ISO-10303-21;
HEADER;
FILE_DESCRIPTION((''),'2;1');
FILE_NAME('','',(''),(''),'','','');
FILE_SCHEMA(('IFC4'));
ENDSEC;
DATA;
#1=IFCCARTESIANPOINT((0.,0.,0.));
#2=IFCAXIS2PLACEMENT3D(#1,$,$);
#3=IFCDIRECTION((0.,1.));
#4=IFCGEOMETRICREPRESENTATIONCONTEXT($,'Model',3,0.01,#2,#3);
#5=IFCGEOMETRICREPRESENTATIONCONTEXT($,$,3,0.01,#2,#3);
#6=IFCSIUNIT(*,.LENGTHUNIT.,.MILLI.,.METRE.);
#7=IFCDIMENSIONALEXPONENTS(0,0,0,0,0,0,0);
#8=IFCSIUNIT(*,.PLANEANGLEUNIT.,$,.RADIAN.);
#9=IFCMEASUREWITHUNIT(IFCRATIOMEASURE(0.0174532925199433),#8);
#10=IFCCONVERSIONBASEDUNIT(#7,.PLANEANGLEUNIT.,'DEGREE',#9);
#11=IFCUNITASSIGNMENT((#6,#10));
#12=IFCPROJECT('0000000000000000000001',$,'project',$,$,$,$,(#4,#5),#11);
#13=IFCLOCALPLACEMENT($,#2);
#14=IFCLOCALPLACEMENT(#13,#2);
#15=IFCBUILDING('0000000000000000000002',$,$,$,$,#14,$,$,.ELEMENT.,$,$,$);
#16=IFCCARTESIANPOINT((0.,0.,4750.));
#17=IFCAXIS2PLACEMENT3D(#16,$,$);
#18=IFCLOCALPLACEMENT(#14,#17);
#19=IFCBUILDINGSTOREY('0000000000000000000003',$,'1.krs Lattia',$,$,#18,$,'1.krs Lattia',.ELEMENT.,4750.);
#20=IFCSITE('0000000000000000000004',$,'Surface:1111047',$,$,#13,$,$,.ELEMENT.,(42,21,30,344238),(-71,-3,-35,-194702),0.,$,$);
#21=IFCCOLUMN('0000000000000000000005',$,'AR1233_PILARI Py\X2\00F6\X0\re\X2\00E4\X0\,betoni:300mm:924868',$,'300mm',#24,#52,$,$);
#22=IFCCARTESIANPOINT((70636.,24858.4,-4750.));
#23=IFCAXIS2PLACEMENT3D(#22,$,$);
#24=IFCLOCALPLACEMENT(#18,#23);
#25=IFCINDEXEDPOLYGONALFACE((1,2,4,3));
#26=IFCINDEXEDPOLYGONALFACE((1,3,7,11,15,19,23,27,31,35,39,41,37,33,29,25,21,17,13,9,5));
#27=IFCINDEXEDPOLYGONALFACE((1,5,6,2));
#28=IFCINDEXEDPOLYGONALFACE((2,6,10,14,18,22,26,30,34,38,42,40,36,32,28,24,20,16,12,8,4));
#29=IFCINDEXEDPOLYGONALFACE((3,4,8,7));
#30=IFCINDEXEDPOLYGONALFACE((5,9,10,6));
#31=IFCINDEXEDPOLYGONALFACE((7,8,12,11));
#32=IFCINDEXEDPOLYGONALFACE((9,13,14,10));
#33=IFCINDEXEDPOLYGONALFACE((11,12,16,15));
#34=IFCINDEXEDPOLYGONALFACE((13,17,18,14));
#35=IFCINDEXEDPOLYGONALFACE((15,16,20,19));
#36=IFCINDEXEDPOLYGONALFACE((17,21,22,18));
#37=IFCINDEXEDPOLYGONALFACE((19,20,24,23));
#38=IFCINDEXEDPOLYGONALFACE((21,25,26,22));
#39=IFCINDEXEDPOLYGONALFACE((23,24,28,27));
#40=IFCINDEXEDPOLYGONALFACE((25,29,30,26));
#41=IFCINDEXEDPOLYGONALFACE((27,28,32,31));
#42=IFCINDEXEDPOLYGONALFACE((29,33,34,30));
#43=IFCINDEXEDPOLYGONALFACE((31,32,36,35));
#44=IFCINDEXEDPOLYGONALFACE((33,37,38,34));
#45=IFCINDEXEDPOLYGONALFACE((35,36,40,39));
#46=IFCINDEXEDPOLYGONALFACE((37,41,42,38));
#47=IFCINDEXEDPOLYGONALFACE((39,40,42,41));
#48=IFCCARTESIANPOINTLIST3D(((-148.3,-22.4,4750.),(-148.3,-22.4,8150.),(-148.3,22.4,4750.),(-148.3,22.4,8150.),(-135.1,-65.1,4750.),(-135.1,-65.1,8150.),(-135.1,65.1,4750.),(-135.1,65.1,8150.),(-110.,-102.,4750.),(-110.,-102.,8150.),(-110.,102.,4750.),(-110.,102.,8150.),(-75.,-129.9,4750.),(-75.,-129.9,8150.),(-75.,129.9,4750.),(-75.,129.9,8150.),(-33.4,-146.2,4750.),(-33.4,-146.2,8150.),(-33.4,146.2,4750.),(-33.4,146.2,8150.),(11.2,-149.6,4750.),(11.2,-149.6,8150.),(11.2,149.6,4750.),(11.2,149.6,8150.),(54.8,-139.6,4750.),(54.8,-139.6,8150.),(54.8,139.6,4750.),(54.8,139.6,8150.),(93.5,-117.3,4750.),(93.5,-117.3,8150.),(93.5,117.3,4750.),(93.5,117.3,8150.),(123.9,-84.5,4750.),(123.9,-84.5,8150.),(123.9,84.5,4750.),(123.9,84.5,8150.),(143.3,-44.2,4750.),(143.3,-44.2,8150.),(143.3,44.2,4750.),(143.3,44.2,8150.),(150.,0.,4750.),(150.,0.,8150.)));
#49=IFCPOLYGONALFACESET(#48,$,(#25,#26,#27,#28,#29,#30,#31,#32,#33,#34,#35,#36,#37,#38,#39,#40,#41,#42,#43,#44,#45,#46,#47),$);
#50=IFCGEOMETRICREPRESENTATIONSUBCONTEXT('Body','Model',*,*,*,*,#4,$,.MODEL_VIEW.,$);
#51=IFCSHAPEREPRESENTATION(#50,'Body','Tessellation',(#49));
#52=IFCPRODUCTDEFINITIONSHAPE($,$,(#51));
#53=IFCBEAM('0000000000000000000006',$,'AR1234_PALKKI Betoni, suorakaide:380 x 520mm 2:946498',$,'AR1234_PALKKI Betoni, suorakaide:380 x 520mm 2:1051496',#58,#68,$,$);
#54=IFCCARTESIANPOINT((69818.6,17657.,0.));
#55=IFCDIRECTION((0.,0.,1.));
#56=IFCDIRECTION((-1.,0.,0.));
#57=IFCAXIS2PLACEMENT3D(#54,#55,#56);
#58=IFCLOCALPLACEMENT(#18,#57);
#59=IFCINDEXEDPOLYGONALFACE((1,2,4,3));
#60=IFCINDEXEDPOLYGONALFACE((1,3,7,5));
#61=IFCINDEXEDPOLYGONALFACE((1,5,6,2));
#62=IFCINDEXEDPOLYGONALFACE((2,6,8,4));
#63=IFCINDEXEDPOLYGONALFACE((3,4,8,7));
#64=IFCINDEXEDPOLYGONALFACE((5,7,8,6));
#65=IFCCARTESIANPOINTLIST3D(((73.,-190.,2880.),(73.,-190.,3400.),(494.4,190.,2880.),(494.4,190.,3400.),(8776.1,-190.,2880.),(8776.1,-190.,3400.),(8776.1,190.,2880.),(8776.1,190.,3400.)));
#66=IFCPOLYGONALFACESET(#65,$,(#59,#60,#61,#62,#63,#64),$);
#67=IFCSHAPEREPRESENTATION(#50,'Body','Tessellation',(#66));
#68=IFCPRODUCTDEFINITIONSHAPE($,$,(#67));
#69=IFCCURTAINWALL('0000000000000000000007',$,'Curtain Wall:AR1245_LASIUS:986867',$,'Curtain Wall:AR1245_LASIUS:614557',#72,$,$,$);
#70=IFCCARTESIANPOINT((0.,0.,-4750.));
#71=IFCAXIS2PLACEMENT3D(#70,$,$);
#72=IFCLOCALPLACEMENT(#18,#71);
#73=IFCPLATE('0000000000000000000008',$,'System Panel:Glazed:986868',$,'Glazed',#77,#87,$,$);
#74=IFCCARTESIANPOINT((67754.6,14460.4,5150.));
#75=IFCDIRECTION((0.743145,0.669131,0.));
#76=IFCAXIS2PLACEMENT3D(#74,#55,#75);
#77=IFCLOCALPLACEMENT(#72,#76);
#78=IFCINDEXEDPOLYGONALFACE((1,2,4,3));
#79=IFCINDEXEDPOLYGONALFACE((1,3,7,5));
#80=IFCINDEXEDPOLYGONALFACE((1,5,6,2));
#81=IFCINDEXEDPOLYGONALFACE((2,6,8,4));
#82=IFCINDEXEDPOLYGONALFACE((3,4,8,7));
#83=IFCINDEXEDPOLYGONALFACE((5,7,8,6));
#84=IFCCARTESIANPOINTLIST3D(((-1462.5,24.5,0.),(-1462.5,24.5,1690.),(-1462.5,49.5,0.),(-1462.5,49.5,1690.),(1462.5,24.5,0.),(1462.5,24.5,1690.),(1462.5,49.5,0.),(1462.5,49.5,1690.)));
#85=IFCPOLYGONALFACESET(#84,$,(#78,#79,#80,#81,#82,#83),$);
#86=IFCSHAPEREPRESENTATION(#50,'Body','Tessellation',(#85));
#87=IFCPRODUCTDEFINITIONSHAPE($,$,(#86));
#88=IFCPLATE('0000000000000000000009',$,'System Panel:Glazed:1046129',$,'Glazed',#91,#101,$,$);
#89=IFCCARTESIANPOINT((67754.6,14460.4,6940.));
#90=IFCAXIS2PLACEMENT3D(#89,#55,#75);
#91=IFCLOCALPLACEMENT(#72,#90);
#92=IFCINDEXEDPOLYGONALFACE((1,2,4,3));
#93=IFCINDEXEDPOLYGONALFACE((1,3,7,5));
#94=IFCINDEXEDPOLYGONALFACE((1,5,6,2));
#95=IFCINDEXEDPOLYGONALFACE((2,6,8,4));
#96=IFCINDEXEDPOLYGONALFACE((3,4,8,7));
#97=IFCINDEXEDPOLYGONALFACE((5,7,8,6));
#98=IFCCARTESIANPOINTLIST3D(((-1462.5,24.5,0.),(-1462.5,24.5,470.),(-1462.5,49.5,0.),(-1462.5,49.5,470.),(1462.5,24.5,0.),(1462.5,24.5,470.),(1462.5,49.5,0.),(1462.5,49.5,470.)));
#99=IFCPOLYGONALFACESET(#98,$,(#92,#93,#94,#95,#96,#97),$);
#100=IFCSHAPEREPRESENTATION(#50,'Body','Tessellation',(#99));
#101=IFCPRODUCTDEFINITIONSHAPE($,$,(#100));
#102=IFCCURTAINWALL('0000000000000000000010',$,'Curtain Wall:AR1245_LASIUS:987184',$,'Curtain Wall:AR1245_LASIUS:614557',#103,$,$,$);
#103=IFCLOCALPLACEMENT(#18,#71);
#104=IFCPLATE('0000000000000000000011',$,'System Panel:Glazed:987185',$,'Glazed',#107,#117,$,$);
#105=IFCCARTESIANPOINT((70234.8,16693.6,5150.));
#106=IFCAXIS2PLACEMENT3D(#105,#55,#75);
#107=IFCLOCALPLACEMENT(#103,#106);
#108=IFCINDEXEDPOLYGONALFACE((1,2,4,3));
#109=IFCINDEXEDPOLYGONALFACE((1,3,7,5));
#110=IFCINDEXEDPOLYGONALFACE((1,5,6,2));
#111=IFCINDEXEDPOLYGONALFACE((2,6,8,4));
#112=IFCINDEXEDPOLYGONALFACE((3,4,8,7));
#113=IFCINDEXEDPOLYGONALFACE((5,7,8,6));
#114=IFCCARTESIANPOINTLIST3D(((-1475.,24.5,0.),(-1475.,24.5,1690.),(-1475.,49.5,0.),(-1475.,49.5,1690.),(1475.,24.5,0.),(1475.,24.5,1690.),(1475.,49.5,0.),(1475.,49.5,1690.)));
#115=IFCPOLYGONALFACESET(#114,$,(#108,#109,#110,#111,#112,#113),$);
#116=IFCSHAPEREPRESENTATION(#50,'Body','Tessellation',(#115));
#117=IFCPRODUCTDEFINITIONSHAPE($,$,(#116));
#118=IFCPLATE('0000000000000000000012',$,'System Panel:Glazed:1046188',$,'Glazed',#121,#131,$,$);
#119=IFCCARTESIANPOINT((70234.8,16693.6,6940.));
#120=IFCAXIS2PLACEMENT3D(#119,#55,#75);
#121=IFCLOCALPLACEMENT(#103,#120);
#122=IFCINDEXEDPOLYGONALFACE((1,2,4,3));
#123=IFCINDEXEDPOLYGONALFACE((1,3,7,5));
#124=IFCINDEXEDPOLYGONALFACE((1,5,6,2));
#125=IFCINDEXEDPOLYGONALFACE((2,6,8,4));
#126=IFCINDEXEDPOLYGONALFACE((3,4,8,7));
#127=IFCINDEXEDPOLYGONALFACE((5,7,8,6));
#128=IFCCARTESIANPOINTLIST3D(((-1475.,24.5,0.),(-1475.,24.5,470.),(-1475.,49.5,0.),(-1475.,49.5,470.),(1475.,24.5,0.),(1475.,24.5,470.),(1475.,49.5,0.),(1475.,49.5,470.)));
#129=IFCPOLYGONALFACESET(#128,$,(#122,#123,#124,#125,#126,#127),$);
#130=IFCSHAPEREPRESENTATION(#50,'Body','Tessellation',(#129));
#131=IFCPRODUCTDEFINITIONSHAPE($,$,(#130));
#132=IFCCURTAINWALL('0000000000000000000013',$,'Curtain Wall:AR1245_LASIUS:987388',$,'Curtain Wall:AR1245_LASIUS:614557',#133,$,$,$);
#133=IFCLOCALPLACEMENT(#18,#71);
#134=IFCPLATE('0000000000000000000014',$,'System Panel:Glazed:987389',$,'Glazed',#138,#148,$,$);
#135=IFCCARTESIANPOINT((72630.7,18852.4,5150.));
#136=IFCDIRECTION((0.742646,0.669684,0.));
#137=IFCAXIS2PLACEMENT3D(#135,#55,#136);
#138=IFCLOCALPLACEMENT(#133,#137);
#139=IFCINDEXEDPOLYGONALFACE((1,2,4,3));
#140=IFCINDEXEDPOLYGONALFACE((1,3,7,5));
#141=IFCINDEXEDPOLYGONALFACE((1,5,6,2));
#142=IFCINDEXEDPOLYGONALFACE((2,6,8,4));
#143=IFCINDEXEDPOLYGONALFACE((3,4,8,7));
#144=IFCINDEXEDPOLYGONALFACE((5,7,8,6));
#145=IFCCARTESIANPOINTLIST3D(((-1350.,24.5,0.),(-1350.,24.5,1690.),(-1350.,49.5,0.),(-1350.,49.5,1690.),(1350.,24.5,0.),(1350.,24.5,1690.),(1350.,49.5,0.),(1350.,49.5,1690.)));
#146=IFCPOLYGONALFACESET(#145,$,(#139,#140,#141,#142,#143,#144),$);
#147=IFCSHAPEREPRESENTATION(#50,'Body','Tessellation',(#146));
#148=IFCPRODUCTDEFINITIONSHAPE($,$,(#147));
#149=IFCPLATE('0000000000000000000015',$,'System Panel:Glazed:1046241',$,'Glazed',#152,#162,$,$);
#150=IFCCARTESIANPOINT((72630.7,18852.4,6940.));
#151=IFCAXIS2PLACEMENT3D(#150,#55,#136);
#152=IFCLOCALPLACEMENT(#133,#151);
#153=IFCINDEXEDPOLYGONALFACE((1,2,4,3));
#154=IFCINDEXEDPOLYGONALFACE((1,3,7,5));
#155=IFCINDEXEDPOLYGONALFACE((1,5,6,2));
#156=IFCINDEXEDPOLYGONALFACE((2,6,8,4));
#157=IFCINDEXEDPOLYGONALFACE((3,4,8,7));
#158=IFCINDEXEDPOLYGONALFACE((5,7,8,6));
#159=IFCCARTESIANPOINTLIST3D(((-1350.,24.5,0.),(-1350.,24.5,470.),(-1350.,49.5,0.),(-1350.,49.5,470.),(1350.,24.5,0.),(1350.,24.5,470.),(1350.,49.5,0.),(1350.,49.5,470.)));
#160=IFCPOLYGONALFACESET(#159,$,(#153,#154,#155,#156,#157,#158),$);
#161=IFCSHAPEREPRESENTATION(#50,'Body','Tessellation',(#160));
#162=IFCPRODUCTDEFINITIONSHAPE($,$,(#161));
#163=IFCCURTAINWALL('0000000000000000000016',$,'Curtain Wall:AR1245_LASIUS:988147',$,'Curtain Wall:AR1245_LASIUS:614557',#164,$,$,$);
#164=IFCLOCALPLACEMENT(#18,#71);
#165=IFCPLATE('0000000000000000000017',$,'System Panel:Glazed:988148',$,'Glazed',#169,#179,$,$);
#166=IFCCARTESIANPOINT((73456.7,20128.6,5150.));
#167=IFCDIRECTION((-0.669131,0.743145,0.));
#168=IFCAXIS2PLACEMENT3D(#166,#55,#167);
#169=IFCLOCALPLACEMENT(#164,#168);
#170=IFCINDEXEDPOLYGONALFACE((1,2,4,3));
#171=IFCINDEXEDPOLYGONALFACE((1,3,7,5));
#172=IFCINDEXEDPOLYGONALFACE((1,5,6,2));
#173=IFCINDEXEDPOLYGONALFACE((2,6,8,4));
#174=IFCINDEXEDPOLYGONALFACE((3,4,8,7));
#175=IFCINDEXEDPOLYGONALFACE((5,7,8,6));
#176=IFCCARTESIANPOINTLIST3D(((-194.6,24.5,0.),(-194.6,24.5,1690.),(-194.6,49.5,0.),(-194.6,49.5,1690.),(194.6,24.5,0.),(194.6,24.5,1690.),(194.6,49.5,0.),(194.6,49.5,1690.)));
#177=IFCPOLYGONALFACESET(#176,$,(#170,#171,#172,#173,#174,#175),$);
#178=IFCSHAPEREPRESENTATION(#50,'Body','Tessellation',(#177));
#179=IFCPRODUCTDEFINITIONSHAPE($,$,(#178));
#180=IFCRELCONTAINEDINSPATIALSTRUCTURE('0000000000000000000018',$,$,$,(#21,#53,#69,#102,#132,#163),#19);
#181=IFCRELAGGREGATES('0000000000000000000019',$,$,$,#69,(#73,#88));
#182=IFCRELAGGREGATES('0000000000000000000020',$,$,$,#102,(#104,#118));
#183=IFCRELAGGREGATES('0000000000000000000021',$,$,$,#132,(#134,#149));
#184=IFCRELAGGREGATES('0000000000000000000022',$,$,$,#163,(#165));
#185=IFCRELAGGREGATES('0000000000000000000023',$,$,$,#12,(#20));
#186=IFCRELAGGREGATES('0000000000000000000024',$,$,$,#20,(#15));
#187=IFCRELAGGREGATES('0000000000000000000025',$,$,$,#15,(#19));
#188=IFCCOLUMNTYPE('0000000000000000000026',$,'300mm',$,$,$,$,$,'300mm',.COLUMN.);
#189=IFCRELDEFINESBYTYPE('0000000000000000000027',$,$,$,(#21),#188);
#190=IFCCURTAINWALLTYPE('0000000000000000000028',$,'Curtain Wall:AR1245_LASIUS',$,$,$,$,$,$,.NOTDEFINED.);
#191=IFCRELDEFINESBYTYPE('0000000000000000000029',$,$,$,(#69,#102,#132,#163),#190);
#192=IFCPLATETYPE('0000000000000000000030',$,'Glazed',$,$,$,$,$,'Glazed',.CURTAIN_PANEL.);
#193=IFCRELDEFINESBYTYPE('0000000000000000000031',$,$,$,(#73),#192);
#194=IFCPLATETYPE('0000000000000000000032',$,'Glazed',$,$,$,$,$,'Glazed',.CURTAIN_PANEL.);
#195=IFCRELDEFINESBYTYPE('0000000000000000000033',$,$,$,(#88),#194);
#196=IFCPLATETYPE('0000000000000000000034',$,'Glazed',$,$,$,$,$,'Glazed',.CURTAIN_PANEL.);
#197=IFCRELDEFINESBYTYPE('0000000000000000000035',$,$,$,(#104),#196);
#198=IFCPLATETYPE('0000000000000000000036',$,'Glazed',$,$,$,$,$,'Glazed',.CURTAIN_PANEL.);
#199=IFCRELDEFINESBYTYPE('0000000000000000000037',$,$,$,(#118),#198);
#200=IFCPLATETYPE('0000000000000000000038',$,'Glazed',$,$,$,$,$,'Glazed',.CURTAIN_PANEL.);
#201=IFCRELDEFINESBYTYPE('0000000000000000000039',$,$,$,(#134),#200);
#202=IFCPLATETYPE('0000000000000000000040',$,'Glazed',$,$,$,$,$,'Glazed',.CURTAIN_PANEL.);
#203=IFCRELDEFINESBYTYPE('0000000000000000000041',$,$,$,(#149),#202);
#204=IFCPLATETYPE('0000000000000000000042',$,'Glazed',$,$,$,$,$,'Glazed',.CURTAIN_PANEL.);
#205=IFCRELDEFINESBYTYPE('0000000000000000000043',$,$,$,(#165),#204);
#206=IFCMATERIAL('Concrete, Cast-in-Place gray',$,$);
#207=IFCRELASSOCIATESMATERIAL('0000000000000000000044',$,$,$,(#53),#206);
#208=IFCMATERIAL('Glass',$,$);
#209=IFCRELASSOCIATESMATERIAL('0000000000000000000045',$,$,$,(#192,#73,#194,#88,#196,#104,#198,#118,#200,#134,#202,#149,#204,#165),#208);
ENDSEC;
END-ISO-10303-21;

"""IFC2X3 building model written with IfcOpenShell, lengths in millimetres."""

from ifc_helpers import new_model, entity, si_unit, converted_unit, direction, frame, frame_2d, origin, origin_2d_with_axis, place, context, subcontext, project, spatial, rectangle, circle, extrude, clip, halfspace, source, transform, mapped, material, type_object, type_shapes, element, aggregate, save


model = new_model("IFC2X3")

# Units and contexts
model_context = context("Model", 3, precision=0.01, world=origin(), true_north=direction((0.0, 1.0)))
context_of_model = context(None, 3, precision=0.01, world=origin(), true_north=direction((0.0, 1.0)))
body_context = subcontext(model_context, "Body", "Model", "MODEL_VIEW")
ifc_project = project(units=[si_unit("LENGTHUNIT", "METRE", prefix="MILLI"), converted_unit("PLANEANGLEUNIT", "DEGREE", entity("IfcRatioMeasure", 0.0174532925199433), si_unit("PLANEANGLEUNIT", "RADIAN"), dimensions=[0, 0, 0, 0, 0, 0, 0])], contexts=[model_context, context_of_model])

# Site, building, storey
site_placement = place(None, origin())
site = spatial("IfcSite", under=ifc_project, at=site_placement, Name="Surface:1111047", CompositionType="ELEMENT", RefLatitude=(42, 21, 30, 344238), RefLongitude=(-71, -3, -35, -194702), RefElevation=0.0)
building_placement = place(site_placement, origin())
building = spatial("IfcBuilding", under=site, at=building_placement, CompositionType="ELEMENT")
storey_placement = place(building_placement, frame((0.0, 0.0, 4750.0)))
storey = spatial("IfcBuildingStorey", under=building, at=storey_placement, Name="1.krs Lattia", LongName="1.krs Lattia", CompositionType="ELEMENT", Elevation=4750.0)

# Column
column_type = type_object("IfcColumnType", Name="300mm", ElementType="300mm", PredefinedType="COLUMN")
shared_shape_1 = source(origin(), body_context, "Body", "SweptSolid", [
    extrude(circle(Radius=150.0, at=frame_2d((0.0, 0.0), x_axis=(1.0, 0.0))), frame((0.0, 0.0, 4750.0)), (0.0, 0.0, 1.0), 3400.0),
])
type_shapes(column_type, [shared_shape_1])
column_placement = place(storey_placement, frame((70636.0, 24858.4, -4750.0)))
element("IfcColumn", 1, at=column_placement, inside=storey, type_object=column_type, Name="AR1233_PILARI Pyöreä,betoni:300mm:924868", ObjectType="300mm", context=body_context, shape_type="MappedRepresentation", body=[
    mapped(shared_shape_1, transform((0.0, 0.0, 0.0), scale=1.0)),
])

# Beam
ifc_material_1 = material(Name="Concrete, Cast-in-Place gray")
beam_placement = place(storey_placement, frame((69818.6, 17657.0, 0.0), z_axis=(0.0, 0.0, 1.0), x_axis=(-1.0, 0.0, 0.0)))
element("IfcBeam", 2, at=beam_placement, inside=storey, material=ifc_material_1, Name="AR1234_PALKKI Betoni, suorakaide:380 x 520mm 2:946498", ObjectType="AR1234_PALKKI Betoni, suorakaide:380 x 520mm 2:1051496", context=body_context, shape_type="Clipping", body=[
    clip(extrude(rectangle(XDim=520.0, YDim=380.0, at=frame_2d((0.0, 0.0), x_axis=(1.0, 0.0))), frame((73.0, 0.0, 3140.0), z_axis=(1.0, 0.0, 0.0), x_axis=(0.0, 0.0, -1.0)), (0.0, 0.0, 1.0), 8703.1), halfspace(frame((-11726.3, -10830.1, 2880.0), z_axis=(-0.669684, 0.742646, 0.0), x_axis=(-0.742646, -0.669684, 0.0)), False)),
])

# Curtain walls, plates
curtain_wall_type = type_object("IfcCurtainWallType", Name="Curtain Wall:AR1245_LASIUS", PredefinedType="NOTDEFINED")
curtain_wall_1_placement = place(storey_placement, frame((0.0, 0.0, -4750.0)))
curtain_wall_1 = element("IfcCurtainWall", 3, at=curtain_wall_1_placement, inside=storey, type_object=curtain_wall_type, Name="Curtain Wall:AR1245_LASIUS:986867", ObjectType="Curtain Wall:AR1245_LASIUS:614557")
ifc_material_2 = material(Name="Glass")
plate_type_1 = type_object("IfcPlateType", Name="Glazed", ElementType="Glazed", PredefinedType="CURTAIN_PANEL", material=ifc_material_2)
shared_shape_2 = source(origin(), body_context, "Body", "SweptSolid", [
    extrude(rectangle(XDim=25.0, YDim=2925.0, at=frame_2d((0.0, 0.0), x_axis=(1.0, 0.0))), frame((0.0, 37.0, 0.0), z_axis=(0.0, 0.0, 1.0), x_axis=(0.0, 1.0, 0.0)), (0.0, 0.0, 1.0), 1690.0),
])
type_shapes(plate_type_1, [shared_shape_2])
plate_1_placement = place(curtain_wall_1_placement, frame((67754.6, 14460.4, 5150.0), z_axis=(0.0, 0.0, 1.0), x_axis=(0.743145, 0.669131, 0.0)))
plate_1 = element("IfcPlate", 4, at=plate_1_placement, type_object=plate_type_1, material=ifc_material_2, Name="System Panel:Glazed:986868", ObjectType="Glazed", context=body_context, shape_type="MappedRepresentation", body=[
    mapped(shared_shape_2, transform((0.0, 0.0, 0.0), scale=1.0)),
])
plate_type_2 = type_object("IfcPlateType", Name="Glazed", ElementType="Glazed", PredefinedType="CURTAIN_PANEL", material=ifc_material_2)
shared_shape_3 = source(origin(), body_context, "Body", "SweptSolid", [
    extrude(rectangle(XDim=25.0, YDim=2925.0, at=frame_2d((0.0, 0.0), x_axis=(1.0, 0.0))), frame((0.0, 37.0, 0.0), z_axis=(0.0, 0.0, 1.0), x_axis=(0.0, 1.0, 0.0)), (0.0, 0.0, 1.0), 470.0),
])
type_shapes(plate_type_2, [shared_shape_3])
plate_2_placement = place(curtain_wall_1_placement, frame((67754.6, 14460.4, 6940.0), z_axis=(0.0, 0.0, 1.0), x_axis=(0.743145, 0.669131, 0.0)))
plate_2 = element("IfcPlate", 5, at=plate_2_placement, type_object=plate_type_2, material=ifc_material_2, Name="System Panel:Glazed:1046129", ObjectType="Glazed", context=body_context, shape_type="MappedRepresentation", body=[
    mapped(shared_shape_3, transform((0.0, 0.0, 0.0), scale=1.0)),
])
aggregate(curtain_wall_1, [plate_1, plate_2])
curtain_wall_2_placement = place(storey_placement, frame((0.0, 0.0, -4750.0)))
curtain_wall_2 = element("IfcCurtainWall", 6, at=curtain_wall_2_placement, inside=storey, type_object=curtain_wall_type, Name="Curtain Wall:AR1245_LASIUS:987184", ObjectType="Curtain Wall:AR1245_LASIUS:614557")
plate_type_3 = type_object("IfcPlateType", Name="Glazed", ElementType="Glazed", PredefinedType="CURTAIN_PANEL", material=ifc_material_2)
shared_shape_4 = source(origin(), body_context, "Body", "SweptSolid", [
    extrude(rectangle(XDim=25.0, YDim=2950.0, at=frame_2d((0.0, 0.0), x_axis=(1.0, 0.0))), frame((0.0, 37.0, 0.0), z_axis=(0.0, 0.0, 1.0), x_axis=(0.0, 1.0, 0.0)), (0.0, 0.0, 1.0), 1690.0),
])
type_shapes(plate_type_3, [shared_shape_4])
plate_3_placement = place(curtain_wall_2_placement, frame((70234.8, 16693.6, 5150.0), z_axis=(0.0, 0.0, 1.0), x_axis=(0.743145, 0.669131, 0.0)))
plate_3 = element("IfcPlate", 7, at=plate_3_placement, type_object=plate_type_3, material=ifc_material_2, Name="System Panel:Glazed:987185", ObjectType="Glazed", context=body_context, shape_type="MappedRepresentation", body=[
    mapped(shared_shape_4, transform((0.0, 0.0, 0.0), scale=1.0)),
])
plate_type_4 = type_object("IfcPlateType", Name="Glazed", ElementType="Glazed", PredefinedType="CURTAIN_PANEL", material=ifc_material_2)
shared_shape_5 = source(origin(), body_context, "Body", "SweptSolid", [
    extrude(rectangle(XDim=25.0, YDim=2950.0, at=frame_2d((0.0, 0.0), x_axis=(1.0, 0.0))), frame((0.0, 37.0, 0.0), z_axis=(0.0, 0.0, 1.0), x_axis=(0.0, 1.0, 0.0)), (0.0, 0.0, 1.0), 470.0),
])
type_shapes(plate_type_4, [shared_shape_5])
plate_4_placement = place(curtain_wall_2_placement, frame((70234.8, 16693.6, 6940.0), z_axis=(0.0, 0.0, 1.0), x_axis=(0.743145, 0.669131, 0.0)))
plate_4 = element("IfcPlate", 8, at=plate_4_placement, type_object=plate_type_4, material=ifc_material_2, Name="System Panel:Glazed:1046188", ObjectType="Glazed", context=body_context, shape_type="MappedRepresentation", body=[
    mapped(shared_shape_5, transform((0.0, 0.0, 0.0), scale=1.0)),
])
aggregate(curtain_wall_2, [plate_3, plate_4])
curtain_wall_3_placement = place(storey_placement, frame((0.0, 0.0, -4750.0)))
curtain_wall_3 = element("IfcCurtainWall", 9, at=curtain_wall_3_placement, inside=storey, type_object=curtain_wall_type, Name="Curtain Wall:AR1245_LASIUS:987388", ObjectType="Curtain Wall:AR1245_LASIUS:614557")
plate_type_5 = type_object("IfcPlateType", Name="Glazed", ElementType="Glazed", PredefinedType="CURTAIN_PANEL", material=ifc_material_2)
shared_shape_6 = source(origin(), body_context, "Body", "SweptSolid", [
    extrude(rectangle(XDim=25.0, YDim=2700.0, at=origin_2d_with_axis()), frame((0.0, 37.0, 0.0), z_axis=(0.0, 0.0, 1.0), x_axis=(0.0, 1.0, 0.0)), (0.0, 0.0, 1.0), 1690.0),
])
type_shapes(plate_type_5, [shared_shape_6])
plate_5_placement = place(curtain_wall_3_placement, frame((72630.7, 18852.4, 5150.0), z_axis=(0.0, 0.0, 1.0), x_axis=(0.742646, 0.669684, 0.0)))
plate_5 = element("IfcPlate", 10, at=plate_5_placement, type_object=plate_type_5, material=ifc_material_2, Name="System Panel:Glazed:987389", ObjectType="Glazed", context=body_context, shape_type="MappedRepresentation", body=[
    mapped(shared_shape_6, transform((0.0, 0.0, 0.0), scale=1.0)),
])
plate_type_6 = type_object("IfcPlateType", Name="Glazed", ElementType="Glazed", PredefinedType="CURTAIN_PANEL", material=ifc_material_2)
shared_shape_7 = source(origin(), body_context, "Body", "SweptSolid", [
    extrude(rectangle(XDim=25.0, YDim=2700.0, at=origin_2d_with_axis()), frame((0.0, 37.0, 0.0), z_axis=(0.0, 0.0, 1.0), x_axis=(0.0, 1.0, 0.0)), (0.0, 0.0, 1.0), 470.0),
])
type_shapes(plate_type_6, [shared_shape_7])
plate_6_placement = place(curtain_wall_3_placement, frame((72630.7, 18852.4, 6940.0), z_axis=(0.0, 0.0, 1.0), x_axis=(0.742646, 0.669684, 0.0)))
plate_6 = element("IfcPlate", 11, at=plate_6_placement, type_object=plate_type_6, material=ifc_material_2, Name="System Panel:Glazed:1046241", ObjectType="Glazed", context=body_context, shape_type="MappedRepresentation", body=[
    mapped(shared_shape_7, transform((0.0, 0.0, 0.0), scale=1.0)),
])
aggregate(curtain_wall_3, [plate_5, plate_6])
curtain_wall_4_placement = place(storey_placement, frame((0.0, 0.0, -4750.0)))
curtain_wall_4 = element("IfcCurtainWall", 12, at=curtain_wall_4_placement, inside=storey, type_object=curtain_wall_type, Name="Curtain Wall:AR1245_LASIUS:988147", ObjectType="Curtain Wall:AR1245_LASIUS:614557")
plate_type_7 = type_object("IfcPlateType", Name="Glazed", ElementType="Glazed", PredefinedType="CURTAIN_PANEL", material=ifc_material_2)
shared_shape_8 = source(origin(), body_context, "Body", "SweptSolid", [
    extrude(rectangle(XDim=25.0, YDim=389.3, at=frame_2d((0.0, 0.0), x_axis=(1.0, 0.0))), frame((0.0, 37.0, 0.0), z_axis=(0.0, 0.0, 1.0), x_axis=(0.0, 1.0, 0.0)), (0.0, 0.0, 1.0), 1690.0),
])
type_shapes(plate_type_7, [shared_shape_8])
plate_7_placement = place(curtain_wall_4_placement, frame((73456.7, 20128.6, 5150.0), z_axis=(0.0, 0.0, 1.0), x_axis=(-0.669131, 0.743145, 0.0)))
plate_7 = element("IfcPlate", 13, at=plate_7_placement, type_object=plate_type_7, material=ifc_material_2, Name="System Panel:Glazed:988148", ObjectType="Glazed", context=body_context, shape_type="MappedRepresentation", body=[
    mapped(shared_shape_8, transform((0.0, 0.0, 0.0), scale=1.0)),
])
aggregate(curtain_wall_4, [plate_7])

save(model, "model.ifc")
